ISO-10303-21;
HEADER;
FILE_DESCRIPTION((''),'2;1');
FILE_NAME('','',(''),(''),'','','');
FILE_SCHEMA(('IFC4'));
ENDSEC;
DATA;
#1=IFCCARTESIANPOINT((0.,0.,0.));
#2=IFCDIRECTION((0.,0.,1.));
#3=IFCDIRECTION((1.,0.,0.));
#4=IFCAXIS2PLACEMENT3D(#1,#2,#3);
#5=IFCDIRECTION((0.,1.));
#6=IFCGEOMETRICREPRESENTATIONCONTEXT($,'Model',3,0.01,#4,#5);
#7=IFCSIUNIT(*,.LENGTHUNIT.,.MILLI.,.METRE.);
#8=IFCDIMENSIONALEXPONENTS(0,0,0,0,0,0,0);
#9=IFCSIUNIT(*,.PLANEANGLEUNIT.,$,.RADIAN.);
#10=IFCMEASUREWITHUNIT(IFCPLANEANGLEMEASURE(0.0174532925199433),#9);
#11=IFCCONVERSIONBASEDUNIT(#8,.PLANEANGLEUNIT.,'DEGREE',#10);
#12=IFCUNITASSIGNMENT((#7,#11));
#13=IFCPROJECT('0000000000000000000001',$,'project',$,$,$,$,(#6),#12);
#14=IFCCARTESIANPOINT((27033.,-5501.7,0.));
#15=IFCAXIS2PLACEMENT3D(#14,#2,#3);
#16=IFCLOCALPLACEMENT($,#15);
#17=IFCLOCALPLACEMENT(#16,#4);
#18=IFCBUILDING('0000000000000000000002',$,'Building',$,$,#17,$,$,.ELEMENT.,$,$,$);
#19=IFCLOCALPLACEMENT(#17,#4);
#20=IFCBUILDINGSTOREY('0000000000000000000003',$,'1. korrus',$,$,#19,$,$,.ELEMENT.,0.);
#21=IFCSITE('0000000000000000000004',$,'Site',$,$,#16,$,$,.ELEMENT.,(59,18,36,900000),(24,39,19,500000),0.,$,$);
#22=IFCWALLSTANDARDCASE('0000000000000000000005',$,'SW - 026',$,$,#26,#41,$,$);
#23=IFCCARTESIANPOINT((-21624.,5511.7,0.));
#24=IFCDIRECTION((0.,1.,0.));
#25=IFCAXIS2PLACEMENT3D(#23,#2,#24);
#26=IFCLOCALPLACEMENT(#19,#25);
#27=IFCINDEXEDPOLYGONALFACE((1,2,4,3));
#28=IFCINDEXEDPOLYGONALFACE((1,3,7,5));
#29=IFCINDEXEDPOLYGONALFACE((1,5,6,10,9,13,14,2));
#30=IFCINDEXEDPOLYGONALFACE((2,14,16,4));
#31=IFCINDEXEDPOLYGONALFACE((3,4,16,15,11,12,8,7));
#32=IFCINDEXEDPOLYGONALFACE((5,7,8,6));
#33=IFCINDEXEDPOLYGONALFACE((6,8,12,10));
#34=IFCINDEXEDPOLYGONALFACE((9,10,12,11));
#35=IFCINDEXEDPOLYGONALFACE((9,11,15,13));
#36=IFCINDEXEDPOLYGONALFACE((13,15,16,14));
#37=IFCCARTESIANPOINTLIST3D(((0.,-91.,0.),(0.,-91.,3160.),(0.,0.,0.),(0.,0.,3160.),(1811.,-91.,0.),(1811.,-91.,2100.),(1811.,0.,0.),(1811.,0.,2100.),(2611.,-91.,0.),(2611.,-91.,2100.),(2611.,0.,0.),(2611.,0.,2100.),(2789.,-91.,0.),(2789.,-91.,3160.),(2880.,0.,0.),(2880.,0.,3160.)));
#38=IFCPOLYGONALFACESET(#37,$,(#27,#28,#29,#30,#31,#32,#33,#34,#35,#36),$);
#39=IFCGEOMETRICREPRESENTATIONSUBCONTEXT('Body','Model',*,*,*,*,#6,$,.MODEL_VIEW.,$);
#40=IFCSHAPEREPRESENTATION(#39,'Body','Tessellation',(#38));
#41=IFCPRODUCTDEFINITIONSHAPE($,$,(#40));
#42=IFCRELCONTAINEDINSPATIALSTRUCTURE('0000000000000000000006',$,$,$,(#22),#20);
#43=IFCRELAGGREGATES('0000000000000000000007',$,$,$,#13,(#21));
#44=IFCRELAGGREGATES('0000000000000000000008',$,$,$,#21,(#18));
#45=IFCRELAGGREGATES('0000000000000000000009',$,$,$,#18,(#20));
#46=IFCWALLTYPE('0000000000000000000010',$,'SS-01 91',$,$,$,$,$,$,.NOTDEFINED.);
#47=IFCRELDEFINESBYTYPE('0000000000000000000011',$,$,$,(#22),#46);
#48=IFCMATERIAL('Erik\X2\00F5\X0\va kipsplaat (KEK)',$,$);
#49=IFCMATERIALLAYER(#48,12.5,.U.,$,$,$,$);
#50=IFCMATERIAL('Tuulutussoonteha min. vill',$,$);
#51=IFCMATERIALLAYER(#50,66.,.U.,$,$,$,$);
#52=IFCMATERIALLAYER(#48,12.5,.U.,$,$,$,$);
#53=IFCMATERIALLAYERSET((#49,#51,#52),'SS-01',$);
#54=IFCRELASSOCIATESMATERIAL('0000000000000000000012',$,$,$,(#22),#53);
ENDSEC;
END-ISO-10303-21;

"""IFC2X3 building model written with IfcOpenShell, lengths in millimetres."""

from ifc_helpers import new_model, entity, si_unit, converted_unit, direction, frame, origin_with_axes, origin_2d_with_axis, place, context, subcontext, project, spatial, polyline, rectangle, outline, extrude, material, layer, layer_set, layer_usage, type_object, element, save


model = new_model("IFC2X3")

# Units and contexts
model_context = context("Model", 3, precision=0.01, world=origin_with_axes(), true_north=direction((0.0, 1.0)))
body_context = subcontext(model_context, "Body", "Model", "MODEL_VIEW")
ifc_project = project(units=[si_unit("LENGTHUNIT", "METRE", prefix="MILLI"), converted_unit("PLANEANGLEUNIT", "DEGREE", entity("IfcPlaneAngleMeasure", 0.0174532925199433), si_unit("PLANEANGLEUNIT", "RADIAN"), dimensions=[0, 0, 0, 0, 0, 0, 0])], contexts=[model_context])

# Site, building, storey
site_placement = place(None, frame((27033.0, -5501.7, 0.0), z_axis=(0.0, 0.0, 1.0), x_axis=(1.0, 0.0, 0.0)))
site = spatial("IfcSite", under=ifc_project, at=site_placement, Name="Site", CompositionType="ELEMENT", RefLatitude=(59, 18, 36, 900000), RefLongitude=(24, 39, 19, 500000), RefElevation=0.0)
building_placement = place(site_placement, origin_with_axes())
building = spatial("IfcBuilding", under=site, at=building_placement, Name="Building", CompositionType="ELEMENT")
storey_placement = place(building_placement, origin_with_axes())
storey = spatial("IfcBuildingStorey", under=building, at=storey_placement, Name="1. korrus", CompositionType="ELEMENT", Elevation=0.0)

# Wall, opening
ifc_material_1 = material(Name="Erikõva kipsplaat (KEK)")
ifc_layer_1 = layer(ifc_material_1, 12.5, ventilated="UNKNOWN")
ifc_material_2 = material(Name="Tuulutussoonteha min. vill")
ifc_layer_2 = layer(ifc_material_2, 66.0, ventilated="UNKNOWN")
ifc_layer_3 = layer(ifc_material_1, 12.5, ventilated="UNKNOWN")
ifc_layer_set_1 = layer_set([ifc_layer_1, ifc_layer_2, ifc_layer_3], Name="SS-01")
ifc_layer_usage_1 = layer_usage(ifc_layer_set_1, "AXIS2", "POSITIVE", -91.0)
wall_type_1 = type_object("IfcWallType", Name="SS-01 91", PredefinedType="NOTDEFINED")
wall_1_placement = place(storey_placement, frame((-21624.0, 5511.7, 0.0), z_axis=(0.0, 0.0, 1.0), x_axis=(0.0, 1.0, 0.0)))
wall_1 = element("IfcWallStandardCase", 1, at=wall_1_placement, inside=storey, type_object=wall_type_1, material=ifc_layer_usage_1, Name="SW - 026", context=body_context, shape_type="SweptSolid", body=[
    extrude(outline(polyline([(0.0, -91.0), (2789.0, -91.0), (2880.0, 0.0), (0.0, 0.0), (0.0, -91.0)])), origin_with_axes(), (0.0, 0.0, 1.0), 3160.0),
])
opening_1_placement = place(wall_1_placement, frame((2211.0, 0.0, 0.0), z_axis=(0.0, 0.0, 1.0), x_axis=(1.0, 0.0, 0.0)))
element("IfcOpeningElement", 2, at=opening_1_placement, cuts=wall_1, context=body_context, shape_type="SweptSolid", body=[
    extrude(rectangle(XDim=800.0, YDim=2100.0, at=origin_2d_with_axis()), frame((0.0, -91.0, 1050.0), z_axis=(0.0, -1.0, 0.0), x_axis=(-1.0, 0.0, 0.0)), (0.0, 0.0, -1.0), 273.0),
    extrude(rectangle(XDim=874.0, YDim=2137.0, at=origin_2d_with_axis()), frame((0.0, 0.0, 1068.5), z_axis=(0.0, 1.0, 0.0), x_axis=(-1.0, 0.0, 0.0)), (0.0, 0.0, 1.0), 91.0),
])

save(model, "model.ifc")
